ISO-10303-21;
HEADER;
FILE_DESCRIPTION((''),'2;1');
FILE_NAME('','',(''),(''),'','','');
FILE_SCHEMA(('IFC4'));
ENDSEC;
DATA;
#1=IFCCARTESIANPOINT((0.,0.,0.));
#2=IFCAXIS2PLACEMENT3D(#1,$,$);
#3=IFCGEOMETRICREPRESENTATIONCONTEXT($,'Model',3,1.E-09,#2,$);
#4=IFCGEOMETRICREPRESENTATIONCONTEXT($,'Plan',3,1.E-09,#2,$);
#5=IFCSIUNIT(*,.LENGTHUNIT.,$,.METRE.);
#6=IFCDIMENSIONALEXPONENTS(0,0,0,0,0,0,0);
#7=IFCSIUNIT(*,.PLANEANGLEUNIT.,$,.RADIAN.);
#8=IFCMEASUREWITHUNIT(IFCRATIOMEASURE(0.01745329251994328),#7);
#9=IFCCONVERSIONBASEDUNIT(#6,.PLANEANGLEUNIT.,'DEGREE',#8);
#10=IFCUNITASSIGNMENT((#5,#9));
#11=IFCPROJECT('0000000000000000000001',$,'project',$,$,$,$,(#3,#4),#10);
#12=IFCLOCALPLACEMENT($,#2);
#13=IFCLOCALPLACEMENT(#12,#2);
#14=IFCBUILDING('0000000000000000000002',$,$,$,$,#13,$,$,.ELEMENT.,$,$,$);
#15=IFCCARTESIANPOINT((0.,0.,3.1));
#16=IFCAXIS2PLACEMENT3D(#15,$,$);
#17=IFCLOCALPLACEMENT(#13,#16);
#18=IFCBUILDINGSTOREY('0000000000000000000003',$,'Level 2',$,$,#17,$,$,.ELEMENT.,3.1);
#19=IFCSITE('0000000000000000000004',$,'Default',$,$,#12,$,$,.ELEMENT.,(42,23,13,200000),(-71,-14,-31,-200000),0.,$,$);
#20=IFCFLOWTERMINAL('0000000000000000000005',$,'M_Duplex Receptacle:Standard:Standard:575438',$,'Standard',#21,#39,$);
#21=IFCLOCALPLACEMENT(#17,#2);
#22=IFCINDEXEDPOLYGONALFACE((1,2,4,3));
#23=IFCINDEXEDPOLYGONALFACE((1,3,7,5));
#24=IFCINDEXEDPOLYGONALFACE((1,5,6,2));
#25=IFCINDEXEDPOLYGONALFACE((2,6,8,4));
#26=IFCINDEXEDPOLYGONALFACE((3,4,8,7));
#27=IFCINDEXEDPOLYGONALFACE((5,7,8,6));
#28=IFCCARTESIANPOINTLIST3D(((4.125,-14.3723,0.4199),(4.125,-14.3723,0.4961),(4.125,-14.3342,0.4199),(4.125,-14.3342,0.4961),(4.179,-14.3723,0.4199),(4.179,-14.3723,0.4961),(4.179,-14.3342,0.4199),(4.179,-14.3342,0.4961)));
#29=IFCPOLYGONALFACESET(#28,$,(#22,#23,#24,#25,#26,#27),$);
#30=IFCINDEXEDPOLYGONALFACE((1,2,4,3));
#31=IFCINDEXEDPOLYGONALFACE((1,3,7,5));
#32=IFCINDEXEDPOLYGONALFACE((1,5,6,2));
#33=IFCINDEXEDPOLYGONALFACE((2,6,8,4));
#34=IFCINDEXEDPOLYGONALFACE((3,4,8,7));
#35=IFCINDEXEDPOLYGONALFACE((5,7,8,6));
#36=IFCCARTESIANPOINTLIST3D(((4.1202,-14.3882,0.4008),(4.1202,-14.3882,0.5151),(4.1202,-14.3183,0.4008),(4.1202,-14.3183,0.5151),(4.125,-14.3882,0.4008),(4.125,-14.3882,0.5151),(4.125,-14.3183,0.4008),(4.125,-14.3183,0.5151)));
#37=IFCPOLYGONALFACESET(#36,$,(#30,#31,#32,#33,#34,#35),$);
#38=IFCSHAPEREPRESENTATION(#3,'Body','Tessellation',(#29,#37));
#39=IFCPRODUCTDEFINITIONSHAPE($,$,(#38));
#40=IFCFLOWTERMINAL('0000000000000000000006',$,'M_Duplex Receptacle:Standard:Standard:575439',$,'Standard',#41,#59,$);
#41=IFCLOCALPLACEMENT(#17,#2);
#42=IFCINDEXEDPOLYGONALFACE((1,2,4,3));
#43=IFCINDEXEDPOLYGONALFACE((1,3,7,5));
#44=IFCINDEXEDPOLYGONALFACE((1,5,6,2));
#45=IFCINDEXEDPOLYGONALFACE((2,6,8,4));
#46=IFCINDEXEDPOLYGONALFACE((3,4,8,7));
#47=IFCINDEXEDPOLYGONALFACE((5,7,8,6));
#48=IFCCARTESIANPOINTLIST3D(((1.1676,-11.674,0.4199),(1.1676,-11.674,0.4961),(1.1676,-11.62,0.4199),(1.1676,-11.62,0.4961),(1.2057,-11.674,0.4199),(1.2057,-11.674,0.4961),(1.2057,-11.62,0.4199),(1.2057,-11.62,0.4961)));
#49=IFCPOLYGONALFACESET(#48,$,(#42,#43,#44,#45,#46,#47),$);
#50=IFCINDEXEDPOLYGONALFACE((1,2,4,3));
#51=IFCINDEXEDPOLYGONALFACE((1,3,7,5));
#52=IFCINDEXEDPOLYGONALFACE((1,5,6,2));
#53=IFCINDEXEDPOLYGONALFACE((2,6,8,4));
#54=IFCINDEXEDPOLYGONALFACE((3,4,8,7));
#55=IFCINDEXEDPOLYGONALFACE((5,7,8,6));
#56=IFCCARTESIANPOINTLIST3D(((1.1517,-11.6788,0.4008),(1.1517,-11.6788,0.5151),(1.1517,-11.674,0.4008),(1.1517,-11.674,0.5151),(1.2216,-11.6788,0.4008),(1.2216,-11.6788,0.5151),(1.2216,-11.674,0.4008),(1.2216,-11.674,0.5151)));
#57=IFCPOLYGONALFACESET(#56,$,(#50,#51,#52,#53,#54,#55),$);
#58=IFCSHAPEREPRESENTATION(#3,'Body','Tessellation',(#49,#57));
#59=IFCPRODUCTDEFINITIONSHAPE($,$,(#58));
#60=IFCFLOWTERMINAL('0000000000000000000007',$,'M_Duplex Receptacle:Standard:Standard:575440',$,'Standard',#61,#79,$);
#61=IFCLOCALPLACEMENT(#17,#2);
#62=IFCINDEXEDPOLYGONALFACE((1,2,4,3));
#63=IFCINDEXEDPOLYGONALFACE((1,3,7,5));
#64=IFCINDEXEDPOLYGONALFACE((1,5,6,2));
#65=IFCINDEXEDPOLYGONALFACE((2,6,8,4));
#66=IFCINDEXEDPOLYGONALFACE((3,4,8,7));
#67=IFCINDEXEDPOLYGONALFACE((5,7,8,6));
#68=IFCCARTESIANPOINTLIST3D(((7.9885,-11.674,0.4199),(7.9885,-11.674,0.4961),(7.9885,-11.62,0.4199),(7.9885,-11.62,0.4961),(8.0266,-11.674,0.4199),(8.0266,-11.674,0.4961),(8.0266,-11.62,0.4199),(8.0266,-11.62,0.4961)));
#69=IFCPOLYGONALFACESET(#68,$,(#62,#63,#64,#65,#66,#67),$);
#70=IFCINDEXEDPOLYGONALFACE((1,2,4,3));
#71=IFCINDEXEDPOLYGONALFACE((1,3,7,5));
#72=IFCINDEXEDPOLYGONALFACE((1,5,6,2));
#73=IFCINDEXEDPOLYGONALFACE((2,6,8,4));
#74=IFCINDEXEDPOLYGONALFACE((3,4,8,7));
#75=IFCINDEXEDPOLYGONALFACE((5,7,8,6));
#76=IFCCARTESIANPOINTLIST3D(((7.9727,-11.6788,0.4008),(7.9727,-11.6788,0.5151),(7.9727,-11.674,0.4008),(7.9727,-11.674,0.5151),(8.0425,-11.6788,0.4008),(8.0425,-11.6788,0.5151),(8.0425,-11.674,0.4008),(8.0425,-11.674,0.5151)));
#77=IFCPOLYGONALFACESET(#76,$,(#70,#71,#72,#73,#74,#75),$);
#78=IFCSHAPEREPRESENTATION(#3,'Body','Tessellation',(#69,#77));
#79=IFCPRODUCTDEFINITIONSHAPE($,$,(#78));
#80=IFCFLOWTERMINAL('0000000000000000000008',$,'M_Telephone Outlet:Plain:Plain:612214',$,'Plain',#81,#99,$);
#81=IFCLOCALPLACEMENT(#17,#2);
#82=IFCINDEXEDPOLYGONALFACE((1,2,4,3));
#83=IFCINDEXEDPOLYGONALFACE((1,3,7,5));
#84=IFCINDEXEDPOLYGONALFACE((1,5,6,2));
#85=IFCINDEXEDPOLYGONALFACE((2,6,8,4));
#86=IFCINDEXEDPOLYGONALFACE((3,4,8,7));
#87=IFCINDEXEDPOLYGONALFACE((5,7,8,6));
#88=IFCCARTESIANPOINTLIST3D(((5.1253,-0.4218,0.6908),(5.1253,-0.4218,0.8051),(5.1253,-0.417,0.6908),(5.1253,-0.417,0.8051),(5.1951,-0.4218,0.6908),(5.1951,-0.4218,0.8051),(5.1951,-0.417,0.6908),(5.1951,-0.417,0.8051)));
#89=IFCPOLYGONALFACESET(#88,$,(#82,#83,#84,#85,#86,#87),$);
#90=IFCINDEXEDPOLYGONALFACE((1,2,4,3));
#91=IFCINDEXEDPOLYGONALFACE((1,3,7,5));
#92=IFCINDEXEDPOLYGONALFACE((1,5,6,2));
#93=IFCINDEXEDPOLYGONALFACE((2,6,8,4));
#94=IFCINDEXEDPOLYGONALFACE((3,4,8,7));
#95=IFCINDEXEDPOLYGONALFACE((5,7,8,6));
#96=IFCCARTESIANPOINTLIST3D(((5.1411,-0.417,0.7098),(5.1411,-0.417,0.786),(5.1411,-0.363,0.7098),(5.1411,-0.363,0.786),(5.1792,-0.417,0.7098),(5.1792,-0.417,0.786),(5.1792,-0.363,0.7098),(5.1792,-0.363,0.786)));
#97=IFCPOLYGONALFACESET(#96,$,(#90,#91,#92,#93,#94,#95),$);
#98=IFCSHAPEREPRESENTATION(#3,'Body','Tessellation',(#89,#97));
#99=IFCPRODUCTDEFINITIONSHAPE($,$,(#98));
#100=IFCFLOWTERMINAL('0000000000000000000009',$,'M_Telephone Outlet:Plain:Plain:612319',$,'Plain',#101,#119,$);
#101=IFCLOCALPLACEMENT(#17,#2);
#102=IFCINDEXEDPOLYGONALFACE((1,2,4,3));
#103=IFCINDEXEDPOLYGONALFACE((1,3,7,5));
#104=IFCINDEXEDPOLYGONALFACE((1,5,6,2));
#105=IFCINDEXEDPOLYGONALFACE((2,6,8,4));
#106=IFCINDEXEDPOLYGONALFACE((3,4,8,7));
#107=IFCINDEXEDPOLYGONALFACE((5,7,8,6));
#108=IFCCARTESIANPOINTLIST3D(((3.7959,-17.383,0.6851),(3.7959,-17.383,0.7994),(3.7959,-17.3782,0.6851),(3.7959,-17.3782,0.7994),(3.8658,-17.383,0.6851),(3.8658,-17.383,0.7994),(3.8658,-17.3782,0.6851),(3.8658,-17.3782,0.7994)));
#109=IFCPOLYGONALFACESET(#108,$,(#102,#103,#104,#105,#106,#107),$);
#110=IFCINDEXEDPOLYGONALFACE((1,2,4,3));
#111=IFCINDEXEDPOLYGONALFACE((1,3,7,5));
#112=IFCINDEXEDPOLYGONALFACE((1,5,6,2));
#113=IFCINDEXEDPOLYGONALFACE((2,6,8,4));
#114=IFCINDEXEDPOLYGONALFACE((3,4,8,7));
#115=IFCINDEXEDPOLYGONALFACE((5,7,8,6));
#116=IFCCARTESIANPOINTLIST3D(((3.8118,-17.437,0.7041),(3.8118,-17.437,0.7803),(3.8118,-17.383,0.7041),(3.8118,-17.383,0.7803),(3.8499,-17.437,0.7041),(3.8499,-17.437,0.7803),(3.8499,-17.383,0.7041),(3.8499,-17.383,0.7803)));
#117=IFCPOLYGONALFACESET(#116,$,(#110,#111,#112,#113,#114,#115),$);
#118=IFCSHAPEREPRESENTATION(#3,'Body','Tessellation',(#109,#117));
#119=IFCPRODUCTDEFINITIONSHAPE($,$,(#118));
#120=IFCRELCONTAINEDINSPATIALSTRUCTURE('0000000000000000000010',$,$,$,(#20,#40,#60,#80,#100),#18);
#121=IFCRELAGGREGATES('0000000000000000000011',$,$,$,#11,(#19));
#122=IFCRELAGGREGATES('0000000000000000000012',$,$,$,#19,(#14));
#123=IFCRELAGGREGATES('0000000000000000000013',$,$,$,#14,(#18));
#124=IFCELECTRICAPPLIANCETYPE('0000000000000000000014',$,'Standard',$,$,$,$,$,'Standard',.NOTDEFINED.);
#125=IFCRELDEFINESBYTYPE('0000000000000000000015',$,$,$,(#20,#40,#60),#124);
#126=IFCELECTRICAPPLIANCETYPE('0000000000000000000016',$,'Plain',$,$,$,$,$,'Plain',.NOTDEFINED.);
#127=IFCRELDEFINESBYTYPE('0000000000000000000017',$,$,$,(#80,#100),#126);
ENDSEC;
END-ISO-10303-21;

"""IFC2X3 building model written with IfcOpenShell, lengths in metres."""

from ifc_helpers import new_model, entity, si_unit, converted_unit, frame, origin, origin_2d_with_axis, place, context, project, spatial, rectangle, extrude, source, transform, mapped, type_object, type_shapes, element, save


model = new_model("IFC2X3")

# Units and contexts
model_context = context("Model", 3, precision=1e-09, world=origin())
plan_context = context("Plan", 3, precision=1e-09, world=origin())
ifc_project = project(units=[si_unit("LENGTHUNIT", "METRE"), converted_unit("PLANEANGLEUNIT", "DEGREE", entity("IfcRatioMeasure", 0.01745329251994328), si_unit("PLANEANGLEUNIT", "RADIAN"), dimensions=[0, 0, 0, 0, 0, 0, 0])], contexts=[model_context, plan_context])

# Site, building, storey
site_placement = place(None, origin())
site = spatial("IfcSite", under=ifc_project, at=site_placement, Name="Default", CompositionType="ELEMENT", RefLatitude=(42, 23, 13, 200000), RefLongitude=(-71, -14, -31, -200000), RefElevation=0.0)
building_placement = place(site_placement, origin())
building = spatial("IfcBuilding", under=site, at=building_placement, CompositionType="ELEMENT")
storey_placement = place(building_placement, frame((0.0, 0.0, 3.1)))
storey = spatial("IfcBuildingStorey", under=building, at=storey_placement, Name="Level 2", CompositionType="ELEMENT", Elevation=3.1)

# Flow terminals
electric_appliance_type_1 = type_object("IfcElectricApplianceType", Name="Standard", ElementType="Standard", PredefinedType="NOTDEFINED")
shared_shape_1 = source(origin(), model_context, "Body", "SweptSolid", [
    extrude(rectangle(XDim=0.0381, YDim=0.0762, at=origin_2d_with_axis()), frame((0.0, 0.0, -0.054), z_axis=(0.0, 0.0, 1.0), x_axis=(-1.0, 0.0, 0.0)), (0.0, 0.0, 1.0), 0.054),
    extrude(rectangle(XDim=0.0698, YDim=0.1143, at=origin_2d_with_axis()), frame((0.0, 0.0, 0.0), z_axis=(0.0, 0.0, 1.0), x_axis=(-1.0, 0.0, 0.0)), (0.0, 0.0, 1.0), 0.0048),
])
type_shapes(electric_appliance_type_1, [shared_shape_1])
for number, where, z_axis, x_axis, name in (
    (1, (4.125, -14.3533, 0.458), (-1.0, 0.0, 0.0), (0.0, -1.0, 0.0), "M_Duplex Receptacle:Standard:Standard:575438"),
    (2, (1.1866, -11.674, 0.458), (0.0, -1.0, 0.0), (1.0, 0.0, 0.0), "M_Duplex Receptacle:Standard:Standard:575439"),
    (3, (8.0076, -11.674, 0.458), (0.0, -1.0, 0.0), (1.0, 0.0, 0.0), "M_Duplex Receptacle:Standard:Standard:575440"),
):
    element("IfcFlowTerminal", number, at=place(storey_placement, frame(where, z_axis=z_axis, x_axis=x_axis)), inside=storey, type_object=electric_appliance_type_1, Name=name, ObjectType="Standard", context=model_context, shape_type="MappedRepresentation", body=[
        mapped(shared_shape_1, transform((0.0, 0.0, 0.0), scale=1.0)),
    ])
electric_appliance_type_2 = type_object("IfcElectricApplianceType", Name="Plain", ElementType="Plain", PredefinedType="NOTDEFINED")
shared_shape_2 = source(origin(), model_context, "Body", "SweptSolid", [
    extrude(rectangle(XDim=0.0699, YDim=0.1143, at=origin_2d_with_axis()), frame((0.0, 0.0, 0.0), z_axis=(0.0, 0.0, 1.0), x_axis=(-1.0, 0.0, 0.0)), (0.0, 0.0, 1.0), 0.0048),
    extrude(rectangle(XDim=0.0381, YDim=0.0762, at=origin_2d_with_axis()), frame((0.0, 0.0, -0.054), z_axis=(0.0, 0.0, 1.0), x_axis=(-1.0, 0.0, 0.0)), (0.0, 0.0, 1.0), 0.054),
])
type_shapes(electric_appliance_type_2, [shared_shape_2])
for number, where, z_axis, x_axis, name in (
    (4, (5.1602, -0.417, 0.7479), (0.0, -1.0, 0.0), (1.0, 0.0, 0.0), "M_Telephone Outlet:Plain:Plain:612214"),
    (5, (3.8309, -17.383, 0.7422), (0.0, 1.0, 0.0), (-1.0, 0.0, 0.0), "M_Telephone Outlet:Plain:Plain:612319"),
):
    element("IfcFlowTerminal", number, at=place(storey_placement, frame(where, z_axis=z_axis, x_axis=x_axis)), inside=storey, type_object=electric_appliance_type_2, Name=name, ObjectType="Plain", context=model_context, shape_type="MappedRepresentation", body=[
        mapped(shared_shape_2, transform((0.0, 0.0, 0.0), scale=1.0)),
    ])

save(model, "model.ifc")
